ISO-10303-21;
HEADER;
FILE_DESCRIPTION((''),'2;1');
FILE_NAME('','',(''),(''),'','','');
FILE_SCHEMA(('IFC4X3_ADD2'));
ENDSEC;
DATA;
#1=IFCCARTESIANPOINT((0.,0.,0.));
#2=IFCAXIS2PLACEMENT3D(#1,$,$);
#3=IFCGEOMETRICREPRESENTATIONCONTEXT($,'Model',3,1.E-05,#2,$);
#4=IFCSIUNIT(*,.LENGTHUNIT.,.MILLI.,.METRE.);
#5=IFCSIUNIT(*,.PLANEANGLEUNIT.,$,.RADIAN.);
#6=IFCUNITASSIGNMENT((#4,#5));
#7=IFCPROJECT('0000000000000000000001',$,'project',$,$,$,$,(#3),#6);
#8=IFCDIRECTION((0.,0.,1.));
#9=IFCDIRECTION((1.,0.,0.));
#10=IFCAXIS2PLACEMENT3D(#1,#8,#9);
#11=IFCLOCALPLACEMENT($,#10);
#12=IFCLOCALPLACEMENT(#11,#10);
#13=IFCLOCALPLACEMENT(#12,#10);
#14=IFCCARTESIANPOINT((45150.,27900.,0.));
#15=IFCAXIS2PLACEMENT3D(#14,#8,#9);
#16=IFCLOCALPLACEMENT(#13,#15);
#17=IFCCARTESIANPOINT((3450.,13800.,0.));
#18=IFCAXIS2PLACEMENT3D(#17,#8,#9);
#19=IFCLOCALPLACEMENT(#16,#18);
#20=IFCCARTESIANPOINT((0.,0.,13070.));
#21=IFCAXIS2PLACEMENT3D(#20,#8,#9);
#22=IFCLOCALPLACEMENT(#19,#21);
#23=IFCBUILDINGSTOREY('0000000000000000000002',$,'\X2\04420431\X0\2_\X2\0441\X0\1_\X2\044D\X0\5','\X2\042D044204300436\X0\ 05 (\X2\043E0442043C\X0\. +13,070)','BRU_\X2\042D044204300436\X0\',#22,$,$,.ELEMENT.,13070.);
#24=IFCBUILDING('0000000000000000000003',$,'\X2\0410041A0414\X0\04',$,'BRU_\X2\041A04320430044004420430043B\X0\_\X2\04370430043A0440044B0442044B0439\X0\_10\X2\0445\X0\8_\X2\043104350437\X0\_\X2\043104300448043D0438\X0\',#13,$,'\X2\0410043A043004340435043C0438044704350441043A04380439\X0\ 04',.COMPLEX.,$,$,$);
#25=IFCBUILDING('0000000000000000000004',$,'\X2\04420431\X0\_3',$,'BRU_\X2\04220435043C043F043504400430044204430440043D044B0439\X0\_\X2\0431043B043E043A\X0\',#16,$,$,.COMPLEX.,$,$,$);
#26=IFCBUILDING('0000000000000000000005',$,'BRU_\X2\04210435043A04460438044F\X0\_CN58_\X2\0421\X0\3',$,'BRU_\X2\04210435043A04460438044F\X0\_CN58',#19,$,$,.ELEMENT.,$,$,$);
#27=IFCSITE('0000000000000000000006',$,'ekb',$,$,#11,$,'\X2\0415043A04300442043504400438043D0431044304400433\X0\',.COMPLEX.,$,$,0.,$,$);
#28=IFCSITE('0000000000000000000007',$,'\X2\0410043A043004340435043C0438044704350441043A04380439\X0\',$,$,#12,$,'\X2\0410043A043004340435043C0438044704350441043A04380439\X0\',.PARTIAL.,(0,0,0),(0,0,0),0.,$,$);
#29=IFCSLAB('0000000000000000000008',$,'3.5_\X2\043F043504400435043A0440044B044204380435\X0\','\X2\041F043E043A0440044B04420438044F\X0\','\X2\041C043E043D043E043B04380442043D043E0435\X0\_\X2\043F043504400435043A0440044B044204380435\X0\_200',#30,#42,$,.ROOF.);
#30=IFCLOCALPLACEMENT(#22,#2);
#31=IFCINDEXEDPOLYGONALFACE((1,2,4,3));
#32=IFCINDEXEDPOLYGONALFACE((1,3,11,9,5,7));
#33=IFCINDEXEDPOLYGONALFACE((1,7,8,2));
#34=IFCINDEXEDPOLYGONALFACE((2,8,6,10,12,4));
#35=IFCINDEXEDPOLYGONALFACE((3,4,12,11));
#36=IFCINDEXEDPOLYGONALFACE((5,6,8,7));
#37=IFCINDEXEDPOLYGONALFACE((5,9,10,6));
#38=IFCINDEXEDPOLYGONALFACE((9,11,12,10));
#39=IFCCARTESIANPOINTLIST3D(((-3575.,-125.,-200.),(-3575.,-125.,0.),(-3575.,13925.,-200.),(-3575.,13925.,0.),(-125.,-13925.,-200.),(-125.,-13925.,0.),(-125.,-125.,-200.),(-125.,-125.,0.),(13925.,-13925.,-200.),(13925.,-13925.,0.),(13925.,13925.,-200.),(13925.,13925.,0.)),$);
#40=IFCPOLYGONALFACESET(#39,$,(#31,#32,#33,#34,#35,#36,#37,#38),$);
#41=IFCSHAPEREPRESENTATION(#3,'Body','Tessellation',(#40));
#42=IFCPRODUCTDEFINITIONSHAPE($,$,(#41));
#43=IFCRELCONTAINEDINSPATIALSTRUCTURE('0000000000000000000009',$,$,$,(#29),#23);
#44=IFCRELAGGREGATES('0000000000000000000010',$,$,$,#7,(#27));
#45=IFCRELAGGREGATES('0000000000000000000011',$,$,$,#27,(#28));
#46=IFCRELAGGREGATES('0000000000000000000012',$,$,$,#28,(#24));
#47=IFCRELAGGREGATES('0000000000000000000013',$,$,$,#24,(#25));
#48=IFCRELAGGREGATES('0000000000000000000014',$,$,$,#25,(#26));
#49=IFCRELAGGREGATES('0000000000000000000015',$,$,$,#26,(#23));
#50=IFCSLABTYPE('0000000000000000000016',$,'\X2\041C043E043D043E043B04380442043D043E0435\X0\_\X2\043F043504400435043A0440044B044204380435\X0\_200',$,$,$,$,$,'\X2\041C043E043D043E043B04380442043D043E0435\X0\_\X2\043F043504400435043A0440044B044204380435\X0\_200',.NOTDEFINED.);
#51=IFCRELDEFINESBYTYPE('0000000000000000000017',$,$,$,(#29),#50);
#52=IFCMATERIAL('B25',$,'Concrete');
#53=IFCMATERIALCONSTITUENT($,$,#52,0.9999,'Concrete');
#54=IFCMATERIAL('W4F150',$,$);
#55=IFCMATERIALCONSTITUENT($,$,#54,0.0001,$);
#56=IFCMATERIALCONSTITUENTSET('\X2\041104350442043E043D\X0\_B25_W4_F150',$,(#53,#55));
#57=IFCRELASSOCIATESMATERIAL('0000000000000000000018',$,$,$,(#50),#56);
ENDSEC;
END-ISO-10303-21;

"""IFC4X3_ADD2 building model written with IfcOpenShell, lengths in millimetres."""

from ifc_helpers import new_model, si_unit, frame, origin, origin_with_axes, place, context, project, spatial, polyline, outline, extrude, material, constituent, constituent_set, type_object, element, save


model = new_model("IFC4X3_ADD2")

# Units and contexts
model_context = context("Model", 3, precision=1e-05, world=origin())
ifc_project = project(units=[si_unit("LENGTHUNIT", "METRE", prefix="MILLI"), si_unit("PLANEANGLEUNIT", "RADIAN")], contexts=[model_context])

# Sites, buildings, storey
site_1_placement = place(None, origin_with_axes())
site_1 = spatial("IfcSite", under=ifc_project, at=site_1_placement, Name="ekb", LongName="Екатеринбург", CompositionType="COMPLEX", RefElevation=0.0)
site_2_placement = place(site_1_placement, origin_with_axes())
site_2 = spatial("IfcSite", under=site_1, at=site_2_placement, Name="Академический", LongName="Академический", CompositionType="PARTIAL", RefLatitude=(0, 0, 0), RefLongitude=(0, 0, 0), RefElevation=0.0)
building_1_placement = place(site_2_placement, origin_with_axes())
building_1 = spatial("IfcBuilding", under=site_2, at=building_1_placement, Name="АКД04", ObjectType="BRU_Квартал_закрытый_10х8_без_башни", LongName="Академический 04", CompositionType="COMPLEX")
building_2_placement = place(building_1_placement, frame((45150.0, 27900.0, 0.0), z_axis=(0.0, 0.0, 1.0), x_axis=(1.0, 0.0, 0.0)))
building_2 = spatial("IfcBuilding", under=building_1, at=building_2_placement, Name="тб_3", ObjectType="BRU_Температурный_блок", CompositionType="COMPLEX")
building_3_placement = place(building_2_placement, frame((3450.0, 13800.0, 0.0), z_axis=(0.0, 0.0, 1.0), x_axis=(1.0, 0.0, 0.0)))
building_3 = spatial("IfcBuilding", under=building_2, at=building_3_placement, Name="BRU_Секция_CN58_С3", ObjectType="BRU_Секция_CN58", CompositionType="ELEMENT")
storey_placement = place(building_3_placement, frame((0.0, 0.0, 13070.0), z_axis=(0.0, 0.0, 1.0), x_axis=(1.0, 0.0, 0.0)))
storey = spatial("IfcBuildingStorey", under=building_3, at=storey_placement, Name="тб2_с1_э5", Description="Этаж 05 (отм. +13,070)", ObjectType="BRU_Этаж", CompositionType="ELEMENT", Elevation=13070.0)

# Shared definitions
ifc_material_1 = material(Name="B25", Category="Concrete")
ifc_material_2 = material(Name="W4F150")

# Slab
ifc_constituent_1 = constituent(ifc_material_1, Category="Concrete", fraction=0.9999)
ifc_constituent_2 = constituent(ifc_material_2, fraction=0.0001)
ifc_constituent_set_1 = constituent_set(constituents=[ifc_constituent_1, ifc_constituent_2], Name="Бетон_B25_W4_F150")
slab_type = type_object("IfcSlabType", Name="Монолитное_перекрытие_200", ElementType="Монолитное_перекрытие_200", PredefinedType="NOTDEFINED", material=ifc_constituent_set_1)
slab_placement = place(storey_placement, frame((0.0, 0.0, -200.0), z_axis=(0.0, 0.0, 1.0), x_axis=(1.0, 0.0, 0.0)))
element("IfcSlab", 1, at=slab_placement, inside=storey, type_object=slab_type, Name="3.5_перекрытие", Description="Покрытия", ObjectType="Монолитное_перекрытие_200", PredefinedType="ROOF", context=model_context, shape_type="SweptSolid", body=[
    extrude(outline(polyline([(-125.0, -13925.0), (13925.0, -13925.0), (13925.0, 13925.0), (-3575.0, 13925.0), (-3575.0, -125.0), (-125.0, -125.0), (-125.0, -13925.0)])), origin_with_axes(), (0.0, 0.0, 1.0), 200.0),
])

save(model, "model.ifc")
